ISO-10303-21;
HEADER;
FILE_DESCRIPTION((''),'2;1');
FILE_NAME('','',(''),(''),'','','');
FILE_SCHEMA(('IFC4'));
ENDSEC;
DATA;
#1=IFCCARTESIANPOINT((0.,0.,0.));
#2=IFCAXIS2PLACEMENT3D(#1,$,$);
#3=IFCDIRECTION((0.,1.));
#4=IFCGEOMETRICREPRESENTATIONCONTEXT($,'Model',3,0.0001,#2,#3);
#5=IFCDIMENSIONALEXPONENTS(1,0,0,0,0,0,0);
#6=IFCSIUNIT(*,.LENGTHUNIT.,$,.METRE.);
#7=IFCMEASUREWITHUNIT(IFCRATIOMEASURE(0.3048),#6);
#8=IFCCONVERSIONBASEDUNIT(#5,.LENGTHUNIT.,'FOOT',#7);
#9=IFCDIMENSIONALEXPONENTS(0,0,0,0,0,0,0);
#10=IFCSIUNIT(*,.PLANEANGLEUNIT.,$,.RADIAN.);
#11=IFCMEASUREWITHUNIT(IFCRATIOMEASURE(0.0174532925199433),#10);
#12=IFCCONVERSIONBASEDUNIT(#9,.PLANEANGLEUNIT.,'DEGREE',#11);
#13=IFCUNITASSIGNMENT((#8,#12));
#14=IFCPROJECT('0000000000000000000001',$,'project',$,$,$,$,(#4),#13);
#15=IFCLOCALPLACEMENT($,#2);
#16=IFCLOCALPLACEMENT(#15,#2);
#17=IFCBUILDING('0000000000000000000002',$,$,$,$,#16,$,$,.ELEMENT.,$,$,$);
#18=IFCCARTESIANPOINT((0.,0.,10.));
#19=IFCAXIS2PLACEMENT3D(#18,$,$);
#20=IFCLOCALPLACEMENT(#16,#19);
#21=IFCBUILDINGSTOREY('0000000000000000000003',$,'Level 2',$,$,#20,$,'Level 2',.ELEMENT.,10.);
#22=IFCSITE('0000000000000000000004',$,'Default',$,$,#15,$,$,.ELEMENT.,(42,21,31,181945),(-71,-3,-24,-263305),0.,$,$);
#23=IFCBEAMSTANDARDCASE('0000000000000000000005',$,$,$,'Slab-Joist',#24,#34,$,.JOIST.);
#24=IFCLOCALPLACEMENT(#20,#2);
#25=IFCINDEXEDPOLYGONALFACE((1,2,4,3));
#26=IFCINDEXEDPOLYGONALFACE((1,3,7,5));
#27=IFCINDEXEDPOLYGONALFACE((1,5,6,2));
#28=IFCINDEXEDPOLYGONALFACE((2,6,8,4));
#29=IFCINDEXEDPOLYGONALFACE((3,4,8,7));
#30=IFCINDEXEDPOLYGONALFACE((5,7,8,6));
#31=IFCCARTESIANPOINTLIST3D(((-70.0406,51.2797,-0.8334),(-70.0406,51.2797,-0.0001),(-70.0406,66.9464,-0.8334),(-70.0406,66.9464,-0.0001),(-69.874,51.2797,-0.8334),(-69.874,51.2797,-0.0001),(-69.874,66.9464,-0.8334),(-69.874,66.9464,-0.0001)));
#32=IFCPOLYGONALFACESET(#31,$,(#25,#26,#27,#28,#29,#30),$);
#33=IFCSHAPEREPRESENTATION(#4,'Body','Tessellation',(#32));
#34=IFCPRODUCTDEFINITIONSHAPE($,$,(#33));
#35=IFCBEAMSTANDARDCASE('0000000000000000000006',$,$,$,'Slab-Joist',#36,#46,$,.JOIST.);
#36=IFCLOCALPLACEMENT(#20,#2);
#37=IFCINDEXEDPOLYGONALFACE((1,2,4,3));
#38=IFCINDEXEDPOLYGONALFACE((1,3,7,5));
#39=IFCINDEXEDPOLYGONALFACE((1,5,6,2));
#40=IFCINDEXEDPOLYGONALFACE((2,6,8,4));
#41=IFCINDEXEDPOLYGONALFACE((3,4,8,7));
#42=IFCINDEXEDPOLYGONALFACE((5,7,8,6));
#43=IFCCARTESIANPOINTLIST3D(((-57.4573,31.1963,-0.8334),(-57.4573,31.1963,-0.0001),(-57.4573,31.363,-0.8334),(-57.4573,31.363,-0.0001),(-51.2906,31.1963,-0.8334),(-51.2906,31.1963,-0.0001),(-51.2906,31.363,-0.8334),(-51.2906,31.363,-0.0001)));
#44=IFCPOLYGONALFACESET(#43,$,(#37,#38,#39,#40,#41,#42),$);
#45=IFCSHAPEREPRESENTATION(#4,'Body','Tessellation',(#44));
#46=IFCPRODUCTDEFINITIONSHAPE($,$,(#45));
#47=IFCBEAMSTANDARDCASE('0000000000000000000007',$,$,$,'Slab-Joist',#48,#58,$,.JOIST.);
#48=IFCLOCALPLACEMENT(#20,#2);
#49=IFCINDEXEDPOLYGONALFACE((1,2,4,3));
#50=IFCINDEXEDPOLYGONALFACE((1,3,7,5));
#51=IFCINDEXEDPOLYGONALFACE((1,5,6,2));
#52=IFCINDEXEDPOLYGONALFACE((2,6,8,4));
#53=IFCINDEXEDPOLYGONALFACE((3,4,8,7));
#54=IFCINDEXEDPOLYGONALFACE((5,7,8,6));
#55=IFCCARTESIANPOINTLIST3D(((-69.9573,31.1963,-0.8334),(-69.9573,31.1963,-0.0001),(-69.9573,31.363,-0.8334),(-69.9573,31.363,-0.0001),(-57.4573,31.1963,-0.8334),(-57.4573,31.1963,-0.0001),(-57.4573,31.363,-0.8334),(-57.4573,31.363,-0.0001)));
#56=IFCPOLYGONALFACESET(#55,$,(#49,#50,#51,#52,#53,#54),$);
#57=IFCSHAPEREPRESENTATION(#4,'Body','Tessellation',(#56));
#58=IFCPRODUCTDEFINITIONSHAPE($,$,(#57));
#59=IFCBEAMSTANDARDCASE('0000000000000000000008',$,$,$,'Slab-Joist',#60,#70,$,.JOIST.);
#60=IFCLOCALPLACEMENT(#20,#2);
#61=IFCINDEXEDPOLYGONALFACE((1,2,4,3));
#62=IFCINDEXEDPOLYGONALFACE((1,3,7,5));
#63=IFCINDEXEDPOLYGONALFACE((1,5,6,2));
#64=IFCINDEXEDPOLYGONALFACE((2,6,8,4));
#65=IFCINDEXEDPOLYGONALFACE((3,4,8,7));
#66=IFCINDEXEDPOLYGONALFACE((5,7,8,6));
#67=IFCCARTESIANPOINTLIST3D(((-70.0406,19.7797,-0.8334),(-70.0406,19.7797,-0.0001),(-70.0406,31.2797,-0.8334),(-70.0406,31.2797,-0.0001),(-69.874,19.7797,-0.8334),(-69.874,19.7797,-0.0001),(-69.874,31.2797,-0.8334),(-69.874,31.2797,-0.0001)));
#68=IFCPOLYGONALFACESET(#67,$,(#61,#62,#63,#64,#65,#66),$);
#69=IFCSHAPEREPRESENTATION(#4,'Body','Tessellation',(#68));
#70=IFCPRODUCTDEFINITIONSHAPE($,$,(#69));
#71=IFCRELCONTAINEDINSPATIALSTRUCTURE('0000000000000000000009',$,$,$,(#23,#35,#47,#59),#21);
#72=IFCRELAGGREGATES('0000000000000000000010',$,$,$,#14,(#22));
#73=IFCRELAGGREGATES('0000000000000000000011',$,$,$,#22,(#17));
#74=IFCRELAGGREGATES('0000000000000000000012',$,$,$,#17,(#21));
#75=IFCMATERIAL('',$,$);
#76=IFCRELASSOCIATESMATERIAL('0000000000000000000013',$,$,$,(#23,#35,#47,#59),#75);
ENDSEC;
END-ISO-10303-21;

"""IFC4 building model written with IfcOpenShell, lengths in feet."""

from ifc_helpers import new_model, entity, si_unit, converted_unit, direction, frame, origin, origin_with_axes, place, context, project, spatial, rectangle, extrude, material, element, save


model = new_model("IFC4")

# Units and contexts
model_context = context("Model", 3, precision=0.0001, world=origin(), true_north=direction((0.0, 1.0)))
ifc_project = project(units=[converted_unit("LENGTHUNIT", "FOOT", entity("IfcRatioMeasure", 0.3048), si_unit("LENGTHUNIT", "METRE"), dimensions=[1, 0, 0, 0, 0, 0, 0]), converted_unit("PLANEANGLEUNIT", "DEGREE", entity("IfcRatioMeasure", 0.0174532925199433), si_unit("PLANEANGLEUNIT", "RADIAN"), dimensions=[0, 0, 0, 0, 0, 0, 0])], contexts=[model_context])

# Site, building, storey
site_placement = place(None, origin())
site = spatial("IfcSite", under=ifc_project, at=site_placement, Name="Default", CompositionType="ELEMENT", RefLatitude=(42, 21, 31, 181945), RefLongitude=(-71, -3, -24, -263305), RefElevation=0.0)
building_placement = place(site_placement, origin())
building = spatial("IfcBuilding", under=site, at=building_placement, CompositionType="ELEMENT")
storey_placement = place(building_placement, frame((0.0, 0.0, 10.0)))
storey = spatial("IfcBuildingStorey", under=building, at=storey_placement, Name="Level 2", LongName="Level 2", CompositionType="ELEMENT", Elevation=10.0)

# Beams
ifc_material = material(Name="")
placement_1 = place(storey_placement, frame((-69.9573, 51.2797, 0.0), z_axis=(0.0, 0.0, 1.0), x_axis=(1.0, 0.0, 0.0)))
beam_1_placement = place(placement_1, frame((0.0, 0.0, -0.4167), z_axis=(0.0, 1.0, 0.0), x_axis=(-1.0, 0.0, 0.0)))
element("IfcBeamStandardCase", 1, at=beam_1_placement, inside=storey, material=ifc_material, ObjectType="Slab-Joist", PredefinedType="JOIST", context=model_context, shape_type="SweptSolid", body=[
    extrude(rectangle(XDim=0.1667, YDim=0.8333), origin_with_axes(), (0.0, 0.0, 1.0), 15.6667),
])
placement_2 = place(storey_placement, frame((-57.4573, 31.2797, 0.0), z_axis=(0.0, 0.0, 1.0), x_axis=(1.0, 0.0, 0.0)))
beam_2_placement = place(placement_2, frame((0.0, 0.0, -0.4167), z_axis=(1.0, 0.0, 0.0), x_axis=(0.0, 1.0, 0.0)))
element("IfcBeamStandardCase", 2, at=beam_2_placement, inside=storey, material=ifc_material, ObjectType="Slab-Joist", PredefinedType="JOIST", context=model_context, shape_type="SweptSolid", body=[
    extrude(rectangle(XDim=0.1667, YDim=0.8333), origin_with_axes(), (0.0, 0.0, 1.0), 6.1667),
])
placement_3 = place(storey_placement, frame((-69.9573, 31.2797, 0.0), z_axis=(0.0, 0.0, 1.0), x_axis=(1.0, 0.0, 0.0)))
beam_3_placement = place(placement_3, frame((0.0, 0.0, -0.4167), z_axis=(1.0, 0.0, 0.0), x_axis=(0.0, 1.0, 0.0)))
element("IfcBeamStandardCase", 3, at=beam_3_placement, inside=storey, material=ifc_material, ObjectType="Slab-Joist", PredefinedType="JOIST", context=model_context, shape_type="SweptSolid", body=[
    extrude(rectangle(XDim=0.1667, YDim=0.8333), origin_with_axes(), (0.0, 0.0, 1.0), 12.5),
])
placement_4 = place(storey_placement, frame((-69.9573, 19.7797, 0.0), z_axis=(0.0, 0.0, 1.0), x_axis=(1.0, 0.0, 0.0)))
beam_4_placement = place(placement_4, frame((0.0, 0.0, -0.4167), z_axis=(0.0, 1.0, 0.0), x_axis=(-1.0, 0.0, 0.0)))
element("IfcBeamStandardCase", 4, at=beam_4_placement, inside=storey, material=ifc_material, ObjectType="Slab-Joist", PredefinedType="JOIST", context=model_context, shape_type="SweptSolid", body=[
    extrude(rectangle(XDim=0.1667, YDim=0.8333), origin_with_axes(), (0.0, 0.0, 1.0), 11.5),
])

save(model, "model.ifc")
